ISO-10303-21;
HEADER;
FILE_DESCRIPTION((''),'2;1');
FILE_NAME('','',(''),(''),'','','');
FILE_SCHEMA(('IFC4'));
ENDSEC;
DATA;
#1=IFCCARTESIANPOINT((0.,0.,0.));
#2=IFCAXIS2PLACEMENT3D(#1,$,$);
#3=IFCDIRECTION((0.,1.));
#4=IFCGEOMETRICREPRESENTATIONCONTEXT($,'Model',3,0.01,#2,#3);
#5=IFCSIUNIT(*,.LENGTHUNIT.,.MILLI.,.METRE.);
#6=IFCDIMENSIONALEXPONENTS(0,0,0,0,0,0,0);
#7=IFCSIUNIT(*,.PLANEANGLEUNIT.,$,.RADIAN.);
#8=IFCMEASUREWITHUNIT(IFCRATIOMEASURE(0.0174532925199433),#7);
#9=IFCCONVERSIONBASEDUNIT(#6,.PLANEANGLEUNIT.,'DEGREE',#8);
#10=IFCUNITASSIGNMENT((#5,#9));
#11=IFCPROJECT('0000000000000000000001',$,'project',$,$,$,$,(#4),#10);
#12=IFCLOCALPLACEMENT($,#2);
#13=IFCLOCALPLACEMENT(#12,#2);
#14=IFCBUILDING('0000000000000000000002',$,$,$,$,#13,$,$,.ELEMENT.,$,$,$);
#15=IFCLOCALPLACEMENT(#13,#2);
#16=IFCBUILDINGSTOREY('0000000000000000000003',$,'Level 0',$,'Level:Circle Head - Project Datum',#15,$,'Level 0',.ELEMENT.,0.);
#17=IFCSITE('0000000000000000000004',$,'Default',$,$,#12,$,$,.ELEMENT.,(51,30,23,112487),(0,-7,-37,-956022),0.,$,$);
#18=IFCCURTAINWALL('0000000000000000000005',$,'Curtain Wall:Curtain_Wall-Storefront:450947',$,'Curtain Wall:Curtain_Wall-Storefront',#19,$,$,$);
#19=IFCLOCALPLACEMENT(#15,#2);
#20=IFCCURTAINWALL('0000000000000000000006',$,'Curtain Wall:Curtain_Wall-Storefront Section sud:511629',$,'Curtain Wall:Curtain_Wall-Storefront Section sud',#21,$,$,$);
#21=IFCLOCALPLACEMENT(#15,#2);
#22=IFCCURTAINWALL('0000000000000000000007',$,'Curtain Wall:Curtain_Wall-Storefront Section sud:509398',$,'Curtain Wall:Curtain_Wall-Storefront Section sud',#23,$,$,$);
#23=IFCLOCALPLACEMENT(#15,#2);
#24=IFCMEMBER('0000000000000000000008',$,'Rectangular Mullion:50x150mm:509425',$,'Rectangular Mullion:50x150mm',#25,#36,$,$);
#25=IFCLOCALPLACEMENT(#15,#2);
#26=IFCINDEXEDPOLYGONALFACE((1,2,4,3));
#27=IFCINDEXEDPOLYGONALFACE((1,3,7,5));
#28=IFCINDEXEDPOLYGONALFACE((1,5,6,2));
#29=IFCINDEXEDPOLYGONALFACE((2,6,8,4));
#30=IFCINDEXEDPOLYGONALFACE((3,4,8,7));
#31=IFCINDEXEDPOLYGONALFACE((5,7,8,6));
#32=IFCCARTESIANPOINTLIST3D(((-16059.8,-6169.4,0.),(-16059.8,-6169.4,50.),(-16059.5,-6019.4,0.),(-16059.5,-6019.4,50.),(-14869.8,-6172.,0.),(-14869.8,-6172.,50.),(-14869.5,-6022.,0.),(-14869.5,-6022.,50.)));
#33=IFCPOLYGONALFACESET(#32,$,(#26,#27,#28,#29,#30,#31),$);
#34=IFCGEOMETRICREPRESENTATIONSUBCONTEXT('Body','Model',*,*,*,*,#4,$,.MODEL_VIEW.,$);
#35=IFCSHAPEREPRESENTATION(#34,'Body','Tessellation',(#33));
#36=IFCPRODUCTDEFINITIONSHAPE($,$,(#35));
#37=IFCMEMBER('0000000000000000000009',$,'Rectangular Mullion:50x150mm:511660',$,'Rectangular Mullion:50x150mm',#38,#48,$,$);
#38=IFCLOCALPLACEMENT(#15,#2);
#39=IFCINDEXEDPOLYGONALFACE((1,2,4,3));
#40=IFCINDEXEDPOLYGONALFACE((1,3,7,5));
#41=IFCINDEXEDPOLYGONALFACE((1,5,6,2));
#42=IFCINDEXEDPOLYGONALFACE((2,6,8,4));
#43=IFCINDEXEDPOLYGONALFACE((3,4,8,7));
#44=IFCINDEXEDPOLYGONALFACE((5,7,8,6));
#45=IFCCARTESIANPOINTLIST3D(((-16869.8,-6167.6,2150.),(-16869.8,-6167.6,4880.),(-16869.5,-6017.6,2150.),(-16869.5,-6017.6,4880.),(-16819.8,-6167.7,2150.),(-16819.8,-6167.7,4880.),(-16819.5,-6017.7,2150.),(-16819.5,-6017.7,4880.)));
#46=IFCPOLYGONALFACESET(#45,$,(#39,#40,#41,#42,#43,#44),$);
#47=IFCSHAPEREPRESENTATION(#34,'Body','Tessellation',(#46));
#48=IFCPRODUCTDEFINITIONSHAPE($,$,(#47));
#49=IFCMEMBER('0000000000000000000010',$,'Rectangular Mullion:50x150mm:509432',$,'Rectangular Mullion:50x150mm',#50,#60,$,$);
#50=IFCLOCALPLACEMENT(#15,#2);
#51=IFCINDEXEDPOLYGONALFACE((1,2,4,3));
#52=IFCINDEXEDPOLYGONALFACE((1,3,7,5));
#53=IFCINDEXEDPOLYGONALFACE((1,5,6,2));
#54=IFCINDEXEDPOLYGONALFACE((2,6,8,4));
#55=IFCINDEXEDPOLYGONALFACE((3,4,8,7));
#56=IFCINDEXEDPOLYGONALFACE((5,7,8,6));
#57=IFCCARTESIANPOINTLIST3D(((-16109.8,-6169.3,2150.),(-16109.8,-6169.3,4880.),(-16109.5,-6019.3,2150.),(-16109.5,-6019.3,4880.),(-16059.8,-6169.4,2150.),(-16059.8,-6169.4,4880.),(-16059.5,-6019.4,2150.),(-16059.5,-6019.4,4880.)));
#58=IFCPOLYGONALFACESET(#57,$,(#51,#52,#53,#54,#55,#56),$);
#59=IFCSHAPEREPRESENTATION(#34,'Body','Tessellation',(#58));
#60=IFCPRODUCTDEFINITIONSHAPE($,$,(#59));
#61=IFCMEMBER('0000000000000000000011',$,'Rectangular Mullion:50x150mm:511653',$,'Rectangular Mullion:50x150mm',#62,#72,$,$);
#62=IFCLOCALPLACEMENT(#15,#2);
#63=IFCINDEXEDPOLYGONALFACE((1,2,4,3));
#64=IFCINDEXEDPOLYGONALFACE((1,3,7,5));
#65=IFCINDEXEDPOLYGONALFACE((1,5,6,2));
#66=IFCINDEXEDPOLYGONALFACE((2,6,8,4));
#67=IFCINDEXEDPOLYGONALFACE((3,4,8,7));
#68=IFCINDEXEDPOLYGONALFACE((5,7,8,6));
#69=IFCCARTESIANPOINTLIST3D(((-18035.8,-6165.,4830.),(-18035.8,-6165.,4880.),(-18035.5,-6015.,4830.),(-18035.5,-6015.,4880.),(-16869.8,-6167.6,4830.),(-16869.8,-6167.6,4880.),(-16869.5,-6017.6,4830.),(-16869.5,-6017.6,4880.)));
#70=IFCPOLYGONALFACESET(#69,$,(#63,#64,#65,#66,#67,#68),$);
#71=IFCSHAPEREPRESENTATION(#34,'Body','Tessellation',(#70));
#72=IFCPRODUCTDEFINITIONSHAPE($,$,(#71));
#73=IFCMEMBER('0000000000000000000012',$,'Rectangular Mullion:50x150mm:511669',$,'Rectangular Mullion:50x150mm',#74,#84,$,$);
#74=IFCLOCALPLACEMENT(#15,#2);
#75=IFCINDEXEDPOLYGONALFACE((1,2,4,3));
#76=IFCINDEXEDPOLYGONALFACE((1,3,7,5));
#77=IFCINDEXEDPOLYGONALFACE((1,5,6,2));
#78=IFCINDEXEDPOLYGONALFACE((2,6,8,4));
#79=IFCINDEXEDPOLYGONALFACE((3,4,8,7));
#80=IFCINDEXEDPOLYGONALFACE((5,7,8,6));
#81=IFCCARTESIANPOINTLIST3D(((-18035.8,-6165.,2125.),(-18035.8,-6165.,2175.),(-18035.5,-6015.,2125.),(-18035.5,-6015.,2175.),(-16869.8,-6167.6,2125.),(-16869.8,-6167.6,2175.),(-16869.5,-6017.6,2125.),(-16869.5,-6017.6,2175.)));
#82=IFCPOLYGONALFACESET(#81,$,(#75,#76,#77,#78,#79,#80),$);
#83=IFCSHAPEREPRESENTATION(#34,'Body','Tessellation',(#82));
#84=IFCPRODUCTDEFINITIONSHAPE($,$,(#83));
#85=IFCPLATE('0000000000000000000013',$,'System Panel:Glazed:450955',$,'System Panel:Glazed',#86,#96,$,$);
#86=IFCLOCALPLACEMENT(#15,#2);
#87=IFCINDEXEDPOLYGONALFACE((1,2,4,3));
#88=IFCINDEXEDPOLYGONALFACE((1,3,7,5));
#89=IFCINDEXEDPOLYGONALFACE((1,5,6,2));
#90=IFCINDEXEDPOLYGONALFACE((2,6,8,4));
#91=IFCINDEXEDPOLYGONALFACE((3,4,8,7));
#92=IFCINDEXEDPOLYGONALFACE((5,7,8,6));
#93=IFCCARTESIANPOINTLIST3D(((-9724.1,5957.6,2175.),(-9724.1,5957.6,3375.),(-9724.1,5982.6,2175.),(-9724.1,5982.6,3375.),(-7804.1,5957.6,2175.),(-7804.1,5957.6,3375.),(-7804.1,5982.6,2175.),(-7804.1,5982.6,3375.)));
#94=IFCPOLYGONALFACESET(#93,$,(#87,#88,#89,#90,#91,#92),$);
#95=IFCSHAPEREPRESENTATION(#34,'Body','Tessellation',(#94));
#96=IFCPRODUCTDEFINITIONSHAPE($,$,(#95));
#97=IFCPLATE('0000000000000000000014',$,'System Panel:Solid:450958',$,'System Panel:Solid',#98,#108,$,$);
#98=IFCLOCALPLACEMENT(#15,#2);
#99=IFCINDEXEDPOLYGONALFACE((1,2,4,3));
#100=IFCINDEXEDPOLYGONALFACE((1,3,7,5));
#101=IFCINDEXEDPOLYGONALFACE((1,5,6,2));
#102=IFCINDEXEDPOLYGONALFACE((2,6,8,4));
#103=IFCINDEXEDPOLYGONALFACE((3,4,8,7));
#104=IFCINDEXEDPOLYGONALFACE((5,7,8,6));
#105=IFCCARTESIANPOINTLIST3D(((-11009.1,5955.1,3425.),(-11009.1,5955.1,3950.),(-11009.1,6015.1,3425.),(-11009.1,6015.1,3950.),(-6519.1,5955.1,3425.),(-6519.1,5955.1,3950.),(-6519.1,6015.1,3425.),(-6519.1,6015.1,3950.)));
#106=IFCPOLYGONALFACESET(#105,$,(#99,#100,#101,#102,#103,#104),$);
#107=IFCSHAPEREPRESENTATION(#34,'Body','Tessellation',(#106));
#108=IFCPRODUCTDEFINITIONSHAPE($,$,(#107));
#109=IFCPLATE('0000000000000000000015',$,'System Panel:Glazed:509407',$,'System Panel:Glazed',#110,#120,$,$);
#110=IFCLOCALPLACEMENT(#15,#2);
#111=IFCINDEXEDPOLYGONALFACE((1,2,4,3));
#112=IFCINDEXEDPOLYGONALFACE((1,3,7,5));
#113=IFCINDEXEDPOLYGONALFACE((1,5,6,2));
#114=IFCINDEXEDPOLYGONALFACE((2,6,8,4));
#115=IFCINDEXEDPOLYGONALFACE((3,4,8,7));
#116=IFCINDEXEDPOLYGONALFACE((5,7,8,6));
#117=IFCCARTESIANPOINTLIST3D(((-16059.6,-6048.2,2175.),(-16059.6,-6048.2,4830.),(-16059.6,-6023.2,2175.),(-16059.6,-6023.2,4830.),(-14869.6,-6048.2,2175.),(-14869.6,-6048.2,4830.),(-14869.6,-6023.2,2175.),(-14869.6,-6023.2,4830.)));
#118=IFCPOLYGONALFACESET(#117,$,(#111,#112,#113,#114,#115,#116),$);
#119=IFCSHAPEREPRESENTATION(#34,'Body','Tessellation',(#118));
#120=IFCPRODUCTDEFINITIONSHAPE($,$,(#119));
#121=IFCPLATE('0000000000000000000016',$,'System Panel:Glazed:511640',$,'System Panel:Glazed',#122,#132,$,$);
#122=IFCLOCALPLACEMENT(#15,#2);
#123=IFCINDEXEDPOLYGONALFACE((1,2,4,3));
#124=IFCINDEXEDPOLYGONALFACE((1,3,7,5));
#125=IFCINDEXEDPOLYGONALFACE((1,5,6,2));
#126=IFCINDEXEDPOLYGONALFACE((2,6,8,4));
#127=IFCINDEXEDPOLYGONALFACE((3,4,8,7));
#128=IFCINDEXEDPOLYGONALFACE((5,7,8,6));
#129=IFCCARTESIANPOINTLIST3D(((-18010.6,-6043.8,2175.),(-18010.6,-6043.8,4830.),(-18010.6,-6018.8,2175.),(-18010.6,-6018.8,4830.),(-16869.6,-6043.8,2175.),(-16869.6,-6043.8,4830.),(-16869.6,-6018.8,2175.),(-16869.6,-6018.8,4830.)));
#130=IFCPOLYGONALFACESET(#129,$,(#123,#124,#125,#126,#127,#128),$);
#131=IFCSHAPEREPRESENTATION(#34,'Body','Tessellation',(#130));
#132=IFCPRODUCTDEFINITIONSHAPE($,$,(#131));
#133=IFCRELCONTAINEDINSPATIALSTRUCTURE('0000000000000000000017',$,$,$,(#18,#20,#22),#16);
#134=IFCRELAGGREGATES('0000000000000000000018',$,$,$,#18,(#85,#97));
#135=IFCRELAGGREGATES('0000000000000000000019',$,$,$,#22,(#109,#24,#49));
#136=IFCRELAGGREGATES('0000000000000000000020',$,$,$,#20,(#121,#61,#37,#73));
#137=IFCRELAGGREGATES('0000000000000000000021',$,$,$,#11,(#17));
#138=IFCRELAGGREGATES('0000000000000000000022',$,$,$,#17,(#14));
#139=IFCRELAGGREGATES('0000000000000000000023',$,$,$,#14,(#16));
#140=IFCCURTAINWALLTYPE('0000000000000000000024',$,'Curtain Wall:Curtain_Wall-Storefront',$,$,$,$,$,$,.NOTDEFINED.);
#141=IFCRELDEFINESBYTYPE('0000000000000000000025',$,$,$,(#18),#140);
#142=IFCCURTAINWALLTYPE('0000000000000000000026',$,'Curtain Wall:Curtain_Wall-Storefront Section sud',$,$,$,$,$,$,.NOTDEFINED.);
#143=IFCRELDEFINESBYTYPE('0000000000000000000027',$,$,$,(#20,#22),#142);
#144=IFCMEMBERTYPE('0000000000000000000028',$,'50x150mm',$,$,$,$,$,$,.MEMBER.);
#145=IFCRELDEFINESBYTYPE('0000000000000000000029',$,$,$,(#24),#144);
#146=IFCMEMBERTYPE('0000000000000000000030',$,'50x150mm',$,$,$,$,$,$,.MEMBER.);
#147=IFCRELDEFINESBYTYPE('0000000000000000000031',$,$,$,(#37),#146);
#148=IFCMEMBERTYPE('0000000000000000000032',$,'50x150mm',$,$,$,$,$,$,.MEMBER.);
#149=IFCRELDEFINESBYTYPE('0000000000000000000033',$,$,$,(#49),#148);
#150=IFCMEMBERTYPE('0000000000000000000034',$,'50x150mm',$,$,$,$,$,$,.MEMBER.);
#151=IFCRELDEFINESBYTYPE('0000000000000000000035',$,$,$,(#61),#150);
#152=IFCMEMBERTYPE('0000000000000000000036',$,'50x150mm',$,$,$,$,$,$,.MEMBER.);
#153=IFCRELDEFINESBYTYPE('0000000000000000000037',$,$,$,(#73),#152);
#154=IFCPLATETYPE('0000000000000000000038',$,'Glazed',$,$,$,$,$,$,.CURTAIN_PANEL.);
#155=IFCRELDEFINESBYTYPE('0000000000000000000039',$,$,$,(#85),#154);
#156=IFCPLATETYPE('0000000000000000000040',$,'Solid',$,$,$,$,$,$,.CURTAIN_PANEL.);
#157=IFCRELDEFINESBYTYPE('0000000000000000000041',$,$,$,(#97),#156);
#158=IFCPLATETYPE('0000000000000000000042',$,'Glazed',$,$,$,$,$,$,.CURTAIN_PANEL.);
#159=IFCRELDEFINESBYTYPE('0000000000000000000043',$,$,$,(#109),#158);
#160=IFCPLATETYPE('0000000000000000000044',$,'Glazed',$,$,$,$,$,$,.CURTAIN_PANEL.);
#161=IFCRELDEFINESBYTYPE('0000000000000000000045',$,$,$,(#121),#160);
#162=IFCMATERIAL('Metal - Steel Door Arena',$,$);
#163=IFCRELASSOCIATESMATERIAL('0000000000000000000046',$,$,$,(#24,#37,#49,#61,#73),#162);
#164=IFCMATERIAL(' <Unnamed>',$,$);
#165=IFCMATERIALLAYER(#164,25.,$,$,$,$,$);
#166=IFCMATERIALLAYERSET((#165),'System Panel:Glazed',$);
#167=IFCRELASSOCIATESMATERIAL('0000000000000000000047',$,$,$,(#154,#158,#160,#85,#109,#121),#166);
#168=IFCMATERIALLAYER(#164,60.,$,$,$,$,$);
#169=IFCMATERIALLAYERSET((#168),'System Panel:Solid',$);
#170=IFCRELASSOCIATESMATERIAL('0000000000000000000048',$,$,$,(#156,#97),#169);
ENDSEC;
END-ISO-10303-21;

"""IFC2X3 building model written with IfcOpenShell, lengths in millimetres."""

from ifc_helpers import new_model, entity, si_unit, converted_unit, direction, frame, frame_2d, origin, origin_2d_with_axis, place, context, subcontext, project, spatial, rectangle, extrude, source, transform, mapped, material, layer, layer_set, layer_usage, type_object, type_shapes, element, aggregate, save


model = new_model("IFC2X3")

# Units and contexts
model_context = context("Model", 3, precision=0.01, world=origin(), true_north=direction((0.0, 1.0)))
body_context = subcontext(model_context, "Body", "Model", "MODEL_VIEW")
ifc_project = project(units=[si_unit("LENGTHUNIT", "METRE", prefix="MILLI"), converted_unit("PLANEANGLEUNIT", "DEGREE", entity("IfcRatioMeasure", 0.0174532925199433), si_unit("PLANEANGLEUNIT", "RADIAN"), dimensions=[0, 0, 0, 0, 0, 0, 0])], contexts=[model_context])

# Site, building, storey
site_placement = place(None, origin())
site = spatial("IfcSite", under=ifc_project, at=site_placement, Name="Default", CompositionType="ELEMENT", RefLatitude=(51, 30, 23, 112487), RefLongitude=(0, -7, -37, -956022), RefElevation=0.0)
building_placement = place(site_placement, origin())
building = spatial("IfcBuilding", under=site, at=building_placement, CompositionType="ELEMENT")
storey_placement = place(building_placement, origin())
storey = spatial("IfcBuildingStorey", under=building, at=storey_placement, Name="Level 0", ObjectType="Level:Circle Head - Project Datum", LongName="Level 0", CompositionType="ELEMENT", Elevation=0.0)

# Curtain walls
curtain_wall_type_1 = type_object("IfcCurtainWallType", Name="Curtain Wall:Curtain_Wall-Storefront", PredefinedType="NOTDEFINED")
curtain_wall_1_placement = place(storey_placement, origin())
curtain_wall_1 = element("IfcCurtainWall", 1, at=curtain_wall_1_placement, inside=storey, type_object=curtain_wall_type_1, Name="Curtain Wall:Curtain_Wall-Storefront:450947", ObjectType="Curtain Wall:Curtain_Wall-Storefront")
ifc_material_1 = material(Name="Metal - Steel Door Arena")
curtain_wall_type_2 = type_object("IfcCurtainWallType", Name="Curtain Wall:Curtain_Wall-Storefront Section sud", PredefinedType="NOTDEFINED")
curtain_wall_2_placement = place(storey_placement, origin())
curtain_wall_2 = element("IfcCurtainWall", 2, at=curtain_wall_2_placement, inside=storey, type_object=curtain_wall_type_2, Name="Curtain Wall:Curtain_Wall-Storefront Section sud:511629", ObjectType="Curtain Wall:Curtain_Wall-Storefront Section sud")
curtain_wall_3_placement = place(storey_placement, origin())
curtain_wall_3 = element("IfcCurtainWall", 3, at=curtain_wall_3_placement, inside=storey, type_object=curtain_wall_type_2, Name="Curtain Wall:Curtain_Wall-Storefront Section sud:509398", ObjectType="Curtain Wall:Curtain_Wall-Storefront Section sud")

# Members
member_type_1 = type_object("IfcMemberType", Name="50x150mm", PredefinedType="MEMBER")
shared_shape_1 = source(origin(), body_context, "Body", "SweptSolid", [
    extrude(rectangle(XDim=150.0, YDim=50.0, at=origin_2d_with_axis()), frame((-25.0, 0.0, -1190.0), z_axis=(0.0, 0.0, 1.0), x_axis=(0.0, -1.0, 0.0)), (0.0, 0.0, 1.0), 1190.0),
])
type_shapes(member_type_1, [shared_shape_1])
member_1_placement = place(storey_placement, frame((-16059.6, -6094.4, 0.0), z_axis=(-0.999998, 0.002199, 0.0), x_axis=(0.0, 0.0, -1.0)))
member_1 = element("IfcMember", 4, at=member_1_placement, type_object=member_type_1, material=ifc_material_1, Name="Rectangular Mullion:50x150mm:509425", ObjectType="Rectangular Mullion:50x150mm", context=body_context, shape_type="MappedRepresentation", body=[
    mapped(shared_shape_1, transform((0.0, 0.0, 0.0), scale=1.0)),
])
member_type_2 = type_object("IfcMemberType", Name="50x150mm", PredefinedType="MEMBER")
shared_shape_2 = source(origin(), body_context, "Body", "SweptSolid", [
    extrude(rectangle(XDim=150.0, YDim=50.0, at=origin_2d_with_axis()), frame((-25.0, 0.0, -2730.0), z_axis=(0.0, 0.0, 1.0), x_axis=(0.0, -1.0, 0.0)), (0.0, 0.0, 1.0), 2730.0),
])
type_shapes(member_type_2, [shared_shape_2])
member_2_placement = place(storey_placement, frame((-16819.6, -6092.7, 2150.0), z_axis=(0.0, 0.0, -1.0), x_axis=(0.999998, -0.002199, 0.0)))
member_2 = element("IfcMember", 5, at=member_2_placement, type_object=member_type_2, material=ifc_material_1, Name="Rectangular Mullion:50x150mm:511660", ObjectType="Rectangular Mullion:50x150mm", context=body_context, shape_type="MappedRepresentation", body=[
    mapped(shared_shape_2, transform((0.0, 0.0, 0.0), scale=1.0)),
])
member_type_3 = type_object("IfcMemberType", Name="50x150mm", PredefinedType="MEMBER")
shared_shape_3 = source(origin(), body_context, "Body", "SweptSolid", [
    extrude(rectangle(XDim=150.0, YDim=50.0, at=origin_2d_with_axis()), frame((-25.0, 0.0, -2730.0), z_axis=(0.0, 0.0, 1.0), x_axis=(0.0, -1.0, 0.0)), (0.0, 0.0, 1.0), 2730.0),
])
type_shapes(member_type_3, [shared_shape_3])
member_3_placement = place(storey_placement, frame((-16109.6, -6094.3, 4880.0), z_axis=(0.0, 0.0, 1.0), x_axis=(-0.999998, 0.002199, 0.0)))
member_3 = element("IfcMember", 6, at=member_3_placement, type_object=member_type_3, material=ifc_material_1, Name="Rectangular Mullion:50x150mm:509432", ObjectType="Rectangular Mullion:50x150mm", context=body_context, shape_type="MappedRepresentation", body=[
    mapped(shared_shape_3, transform((0.0, 0.0, 0.0), scale=1.0)),
])
member_type_4 = type_object("IfcMemberType", Name="50x150mm", PredefinedType="MEMBER")
shared_shape_4 = source(origin(), body_context, "Body", "SweptSolid", [
    extrude(rectangle(XDim=150.0, YDim=50.0, at=origin_2d_with_axis()), frame((-25.0, 0.0, -1166.0), z_axis=(0.0, 0.0, 1.0), x_axis=(0.0, -1.0, 0.0)), (0.0, 0.0, 1.0), 1166.0),
])
type_shapes(member_type_4, [shared_shape_4])
member_4_placement = place(storey_placement, frame((-16869.6, -6092.6, 4880.0), z_axis=(0.999998, -0.002199, 0.0), x_axis=(0.0, 0.0, 1.0)))
member_4 = element("IfcMember", 7, at=member_4_placement, type_object=member_type_4, material=ifc_material_1, Name="Rectangular Mullion:50x150mm:511653", ObjectType="Rectangular Mullion:50x150mm", context=body_context, shape_type="MappedRepresentation", body=[
    mapped(shared_shape_4, transform((0.0, 0.0, 0.0), scale=1.0)),
])
member_type_5 = type_object("IfcMemberType", Name="50x150mm", PredefinedType="MEMBER")
shared_shape_5 = source(origin(), body_context, "Body", "SweptSolid", [
    extrude(rectangle(XDim=150.0, YDim=50.0, at=origin_2d_with_axis()), frame((0.0, 0.0, -1166.0), z_axis=(0.0, 0.0, 1.0), x_axis=(0.0, -1.0, 0.0)), (0.0, 0.0, 1.0), 1166.0),
])
type_shapes(member_type_5, [shared_shape_5])
member_5_placement = place(storey_placement, frame((-16869.6, -6092.6, 2150.0), z_axis=(0.999998, -0.002199, 0.0), x_axis=(0.0, 0.0, 1.0)))
member_5 = element("IfcMember", 8, at=member_5_placement, type_object=member_type_5, material=ifc_material_1, Name="Rectangular Mullion:50x150mm:511669", ObjectType="Rectangular Mullion:50x150mm", context=body_context, shape_type="MappedRepresentation", body=[
    mapped(shared_shape_5, transform((0.0, 0.0, 0.0), scale=1.0)),
])

# Plates
ifc_material_2 = material(Name=" <Unnamed>")
ifc_layer_1 = layer(ifc_material_2, 25.0)
ifc_layer_set_1 = layer_set([ifc_layer_1], Name="System Panel:Glazed")
ifc_layer_usage_1 = layer_usage(ifc_layer_set_1, "AXIS3", "POSITIVE", 0.2)
plate_type_1 = type_object("IfcPlateType", Name="Glazed", PredefinedType="CURTAIN_PANEL", material=ifc_layer_set_1)
shared_shape_6 = source(origin(), body_context, "Body", "SweptSolid", [
    extrude(rectangle(XDim=25.0, YDim=1920.0, at=origin_2d_with_axis()), frame((0.0, 60.0, 0.0), z_axis=(0.0, 0.0, 1.0), x_axis=(0.0, 1.0, 0.0)), (0.0, 0.0, 1.0), 1200.0),
])
type_shapes(plate_type_1, [shared_shape_6])
plate_1_placement = place(curtain_wall_1_placement, frame((-8764.1, 6030.1, 2175.0), z_axis=(0.0, 0.0, 1.0), x_axis=(-1.0, 0.0, 0.0)))
plate_1 = element("IfcPlate", 9, at=plate_1_placement, type_object=plate_type_1, material=ifc_layer_usage_1, Name="System Panel:Glazed:450955", ObjectType="System Panel:Glazed", context=body_context, shape_type="MappedRepresentation", body=[
    mapped(shared_shape_6, transform((0.0, 0.0, 0.0), scale=1.0)),
])
ifc_layer_2 = layer(ifc_material_2, 60.0)
ifc_layer_set_2 = layer_set([ifc_layer_2], Name="System Panel:Solid")
ifc_layer_usage_2 = layer_usage(ifc_layer_set_2, "AXIS3", "POSITIVE", 0.1)
plate_type_2 = type_object("IfcPlateType", Name="Solid", PredefinedType="CURTAIN_PANEL", material=ifc_layer_set_2)
shared_shape_7 = source(origin(), body_context, "Body", "SweptSolid", [
    extrude(rectangle(XDim=525.0, YDim=4490.0, at=frame_2d((0.0, 0.0), x_axis=(1.0, 0.0))), frame((0.0, 15.0, 262.5), z_axis=(0.0, 1.0, 0.0), x_axis=(0.0, 0.0, 1.0)), (0.0, 0.0, 1.0), 60.0),
])
type_shapes(plate_type_2, [shared_shape_7])
plate_2_placement = place(curtain_wall_1_placement, frame((-8764.1, 6030.1, 3425.0), z_axis=(0.0, 0.0, 1.0), x_axis=(-1.0, 0.0, 0.0)))
plate_2 = element("IfcPlate", 10, at=plate_2_placement, type_object=plate_type_2, material=ifc_layer_usage_2, Name="System Panel:Solid:450958", ObjectType="System Panel:Solid", context=body_context, shape_type="MappedRepresentation", body=[
    mapped(shared_shape_7, transform((0.0, 0.0, 0.0), scale=1.0)),
])
aggregate(curtain_wall_1, [plate_1, plate_2])
ifc_layer_usage_3 = layer_usage(ifc_layer_set_1, "AXIS3", "POSITIVE", 0.2)
plate_type_3 = type_object("IfcPlateType", Name="Glazed", PredefinedType="CURTAIN_PANEL", material=ifc_layer_set_1)
shared_shape_8 = source(origin(), body_context, "Body", "SweptSolid", [
    extrude(rectangle(XDim=25.0, YDim=1190.0, at=frame_2d((0.0, 0.0), x_axis=(1.0, 0.0))), frame((0.0, 60.0, 0.0), z_axis=(0.0, 0.0, 1.0), x_axis=(0.0, 1.0, 0.0)), (0.0, 0.0, 1.0), 2655.0),
])
type_shapes(plate_type_3, [shared_shape_8])
plate_3_placement = place(curtain_wall_3_placement, frame((-15464.6, -6095.7, 2175.0)))
plate_3 = element("IfcPlate", 11, at=plate_3_placement, type_object=plate_type_3, material=ifc_layer_usage_3, Name="System Panel:Glazed:509407", ObjectType="System Panel:Glazed", context=body_context, shape_type="MappedRepresentation", body=[
    mapped(shared_shape_8, transform((0.0, 0.0, 0.0), scale=1.0)),
])
aggregate(curtain_wall_3, [plate_3, member_1, member_3])
ifc_layer_usage_4 = layer_usage(ifc_layer_set_1, "AXIS3", "POSITIVE", 0.2)
plate_type_4 = type_object("IfcPlateType", Name="Glazed", PredefinedType="CURTAIN_PANEL", material=ifc_layer_set_1)
shared_shape_9 = source(origin(), body_context, "Body", "SweptSolid", [
    extrude(rectangle(XDim=25.0, YDim=1141.0, at=frame_2d((0.0, 0.0), x_axis=(1.0, 0.0))), frame((0.0, 60.0, 0.0), z_axis=(0.0, 0.0, 1.0), x_axis=(0.0, 1.0, 0.0)), (0.0, 0.0, 1.0), 2655.0),
])
type_shapes(plate_type_4, [shared_shape_9])
plate_4_placement = place(curtain_wall_2_placement, frame((-17440.1, -6091.3, 2175.0)))
plate_4 = element("IfcPlate", 12, at=plate_4_placement, type_object=plate_type_4, material=ifc_layer_usage_4, Name="System Panel:Glazed:511640", ObjectType="System Panel:Glazed", context=body_context, shape_type="MappedRepresentation", body=[
    mapped(shared_shape_9, transform((0.0, 0.0, 0.0), scale=1.0)),
])
aggregate(curtain_wall_2, [plate_4, member_4, member_2, member_5])

save(model, "model.ifc")
